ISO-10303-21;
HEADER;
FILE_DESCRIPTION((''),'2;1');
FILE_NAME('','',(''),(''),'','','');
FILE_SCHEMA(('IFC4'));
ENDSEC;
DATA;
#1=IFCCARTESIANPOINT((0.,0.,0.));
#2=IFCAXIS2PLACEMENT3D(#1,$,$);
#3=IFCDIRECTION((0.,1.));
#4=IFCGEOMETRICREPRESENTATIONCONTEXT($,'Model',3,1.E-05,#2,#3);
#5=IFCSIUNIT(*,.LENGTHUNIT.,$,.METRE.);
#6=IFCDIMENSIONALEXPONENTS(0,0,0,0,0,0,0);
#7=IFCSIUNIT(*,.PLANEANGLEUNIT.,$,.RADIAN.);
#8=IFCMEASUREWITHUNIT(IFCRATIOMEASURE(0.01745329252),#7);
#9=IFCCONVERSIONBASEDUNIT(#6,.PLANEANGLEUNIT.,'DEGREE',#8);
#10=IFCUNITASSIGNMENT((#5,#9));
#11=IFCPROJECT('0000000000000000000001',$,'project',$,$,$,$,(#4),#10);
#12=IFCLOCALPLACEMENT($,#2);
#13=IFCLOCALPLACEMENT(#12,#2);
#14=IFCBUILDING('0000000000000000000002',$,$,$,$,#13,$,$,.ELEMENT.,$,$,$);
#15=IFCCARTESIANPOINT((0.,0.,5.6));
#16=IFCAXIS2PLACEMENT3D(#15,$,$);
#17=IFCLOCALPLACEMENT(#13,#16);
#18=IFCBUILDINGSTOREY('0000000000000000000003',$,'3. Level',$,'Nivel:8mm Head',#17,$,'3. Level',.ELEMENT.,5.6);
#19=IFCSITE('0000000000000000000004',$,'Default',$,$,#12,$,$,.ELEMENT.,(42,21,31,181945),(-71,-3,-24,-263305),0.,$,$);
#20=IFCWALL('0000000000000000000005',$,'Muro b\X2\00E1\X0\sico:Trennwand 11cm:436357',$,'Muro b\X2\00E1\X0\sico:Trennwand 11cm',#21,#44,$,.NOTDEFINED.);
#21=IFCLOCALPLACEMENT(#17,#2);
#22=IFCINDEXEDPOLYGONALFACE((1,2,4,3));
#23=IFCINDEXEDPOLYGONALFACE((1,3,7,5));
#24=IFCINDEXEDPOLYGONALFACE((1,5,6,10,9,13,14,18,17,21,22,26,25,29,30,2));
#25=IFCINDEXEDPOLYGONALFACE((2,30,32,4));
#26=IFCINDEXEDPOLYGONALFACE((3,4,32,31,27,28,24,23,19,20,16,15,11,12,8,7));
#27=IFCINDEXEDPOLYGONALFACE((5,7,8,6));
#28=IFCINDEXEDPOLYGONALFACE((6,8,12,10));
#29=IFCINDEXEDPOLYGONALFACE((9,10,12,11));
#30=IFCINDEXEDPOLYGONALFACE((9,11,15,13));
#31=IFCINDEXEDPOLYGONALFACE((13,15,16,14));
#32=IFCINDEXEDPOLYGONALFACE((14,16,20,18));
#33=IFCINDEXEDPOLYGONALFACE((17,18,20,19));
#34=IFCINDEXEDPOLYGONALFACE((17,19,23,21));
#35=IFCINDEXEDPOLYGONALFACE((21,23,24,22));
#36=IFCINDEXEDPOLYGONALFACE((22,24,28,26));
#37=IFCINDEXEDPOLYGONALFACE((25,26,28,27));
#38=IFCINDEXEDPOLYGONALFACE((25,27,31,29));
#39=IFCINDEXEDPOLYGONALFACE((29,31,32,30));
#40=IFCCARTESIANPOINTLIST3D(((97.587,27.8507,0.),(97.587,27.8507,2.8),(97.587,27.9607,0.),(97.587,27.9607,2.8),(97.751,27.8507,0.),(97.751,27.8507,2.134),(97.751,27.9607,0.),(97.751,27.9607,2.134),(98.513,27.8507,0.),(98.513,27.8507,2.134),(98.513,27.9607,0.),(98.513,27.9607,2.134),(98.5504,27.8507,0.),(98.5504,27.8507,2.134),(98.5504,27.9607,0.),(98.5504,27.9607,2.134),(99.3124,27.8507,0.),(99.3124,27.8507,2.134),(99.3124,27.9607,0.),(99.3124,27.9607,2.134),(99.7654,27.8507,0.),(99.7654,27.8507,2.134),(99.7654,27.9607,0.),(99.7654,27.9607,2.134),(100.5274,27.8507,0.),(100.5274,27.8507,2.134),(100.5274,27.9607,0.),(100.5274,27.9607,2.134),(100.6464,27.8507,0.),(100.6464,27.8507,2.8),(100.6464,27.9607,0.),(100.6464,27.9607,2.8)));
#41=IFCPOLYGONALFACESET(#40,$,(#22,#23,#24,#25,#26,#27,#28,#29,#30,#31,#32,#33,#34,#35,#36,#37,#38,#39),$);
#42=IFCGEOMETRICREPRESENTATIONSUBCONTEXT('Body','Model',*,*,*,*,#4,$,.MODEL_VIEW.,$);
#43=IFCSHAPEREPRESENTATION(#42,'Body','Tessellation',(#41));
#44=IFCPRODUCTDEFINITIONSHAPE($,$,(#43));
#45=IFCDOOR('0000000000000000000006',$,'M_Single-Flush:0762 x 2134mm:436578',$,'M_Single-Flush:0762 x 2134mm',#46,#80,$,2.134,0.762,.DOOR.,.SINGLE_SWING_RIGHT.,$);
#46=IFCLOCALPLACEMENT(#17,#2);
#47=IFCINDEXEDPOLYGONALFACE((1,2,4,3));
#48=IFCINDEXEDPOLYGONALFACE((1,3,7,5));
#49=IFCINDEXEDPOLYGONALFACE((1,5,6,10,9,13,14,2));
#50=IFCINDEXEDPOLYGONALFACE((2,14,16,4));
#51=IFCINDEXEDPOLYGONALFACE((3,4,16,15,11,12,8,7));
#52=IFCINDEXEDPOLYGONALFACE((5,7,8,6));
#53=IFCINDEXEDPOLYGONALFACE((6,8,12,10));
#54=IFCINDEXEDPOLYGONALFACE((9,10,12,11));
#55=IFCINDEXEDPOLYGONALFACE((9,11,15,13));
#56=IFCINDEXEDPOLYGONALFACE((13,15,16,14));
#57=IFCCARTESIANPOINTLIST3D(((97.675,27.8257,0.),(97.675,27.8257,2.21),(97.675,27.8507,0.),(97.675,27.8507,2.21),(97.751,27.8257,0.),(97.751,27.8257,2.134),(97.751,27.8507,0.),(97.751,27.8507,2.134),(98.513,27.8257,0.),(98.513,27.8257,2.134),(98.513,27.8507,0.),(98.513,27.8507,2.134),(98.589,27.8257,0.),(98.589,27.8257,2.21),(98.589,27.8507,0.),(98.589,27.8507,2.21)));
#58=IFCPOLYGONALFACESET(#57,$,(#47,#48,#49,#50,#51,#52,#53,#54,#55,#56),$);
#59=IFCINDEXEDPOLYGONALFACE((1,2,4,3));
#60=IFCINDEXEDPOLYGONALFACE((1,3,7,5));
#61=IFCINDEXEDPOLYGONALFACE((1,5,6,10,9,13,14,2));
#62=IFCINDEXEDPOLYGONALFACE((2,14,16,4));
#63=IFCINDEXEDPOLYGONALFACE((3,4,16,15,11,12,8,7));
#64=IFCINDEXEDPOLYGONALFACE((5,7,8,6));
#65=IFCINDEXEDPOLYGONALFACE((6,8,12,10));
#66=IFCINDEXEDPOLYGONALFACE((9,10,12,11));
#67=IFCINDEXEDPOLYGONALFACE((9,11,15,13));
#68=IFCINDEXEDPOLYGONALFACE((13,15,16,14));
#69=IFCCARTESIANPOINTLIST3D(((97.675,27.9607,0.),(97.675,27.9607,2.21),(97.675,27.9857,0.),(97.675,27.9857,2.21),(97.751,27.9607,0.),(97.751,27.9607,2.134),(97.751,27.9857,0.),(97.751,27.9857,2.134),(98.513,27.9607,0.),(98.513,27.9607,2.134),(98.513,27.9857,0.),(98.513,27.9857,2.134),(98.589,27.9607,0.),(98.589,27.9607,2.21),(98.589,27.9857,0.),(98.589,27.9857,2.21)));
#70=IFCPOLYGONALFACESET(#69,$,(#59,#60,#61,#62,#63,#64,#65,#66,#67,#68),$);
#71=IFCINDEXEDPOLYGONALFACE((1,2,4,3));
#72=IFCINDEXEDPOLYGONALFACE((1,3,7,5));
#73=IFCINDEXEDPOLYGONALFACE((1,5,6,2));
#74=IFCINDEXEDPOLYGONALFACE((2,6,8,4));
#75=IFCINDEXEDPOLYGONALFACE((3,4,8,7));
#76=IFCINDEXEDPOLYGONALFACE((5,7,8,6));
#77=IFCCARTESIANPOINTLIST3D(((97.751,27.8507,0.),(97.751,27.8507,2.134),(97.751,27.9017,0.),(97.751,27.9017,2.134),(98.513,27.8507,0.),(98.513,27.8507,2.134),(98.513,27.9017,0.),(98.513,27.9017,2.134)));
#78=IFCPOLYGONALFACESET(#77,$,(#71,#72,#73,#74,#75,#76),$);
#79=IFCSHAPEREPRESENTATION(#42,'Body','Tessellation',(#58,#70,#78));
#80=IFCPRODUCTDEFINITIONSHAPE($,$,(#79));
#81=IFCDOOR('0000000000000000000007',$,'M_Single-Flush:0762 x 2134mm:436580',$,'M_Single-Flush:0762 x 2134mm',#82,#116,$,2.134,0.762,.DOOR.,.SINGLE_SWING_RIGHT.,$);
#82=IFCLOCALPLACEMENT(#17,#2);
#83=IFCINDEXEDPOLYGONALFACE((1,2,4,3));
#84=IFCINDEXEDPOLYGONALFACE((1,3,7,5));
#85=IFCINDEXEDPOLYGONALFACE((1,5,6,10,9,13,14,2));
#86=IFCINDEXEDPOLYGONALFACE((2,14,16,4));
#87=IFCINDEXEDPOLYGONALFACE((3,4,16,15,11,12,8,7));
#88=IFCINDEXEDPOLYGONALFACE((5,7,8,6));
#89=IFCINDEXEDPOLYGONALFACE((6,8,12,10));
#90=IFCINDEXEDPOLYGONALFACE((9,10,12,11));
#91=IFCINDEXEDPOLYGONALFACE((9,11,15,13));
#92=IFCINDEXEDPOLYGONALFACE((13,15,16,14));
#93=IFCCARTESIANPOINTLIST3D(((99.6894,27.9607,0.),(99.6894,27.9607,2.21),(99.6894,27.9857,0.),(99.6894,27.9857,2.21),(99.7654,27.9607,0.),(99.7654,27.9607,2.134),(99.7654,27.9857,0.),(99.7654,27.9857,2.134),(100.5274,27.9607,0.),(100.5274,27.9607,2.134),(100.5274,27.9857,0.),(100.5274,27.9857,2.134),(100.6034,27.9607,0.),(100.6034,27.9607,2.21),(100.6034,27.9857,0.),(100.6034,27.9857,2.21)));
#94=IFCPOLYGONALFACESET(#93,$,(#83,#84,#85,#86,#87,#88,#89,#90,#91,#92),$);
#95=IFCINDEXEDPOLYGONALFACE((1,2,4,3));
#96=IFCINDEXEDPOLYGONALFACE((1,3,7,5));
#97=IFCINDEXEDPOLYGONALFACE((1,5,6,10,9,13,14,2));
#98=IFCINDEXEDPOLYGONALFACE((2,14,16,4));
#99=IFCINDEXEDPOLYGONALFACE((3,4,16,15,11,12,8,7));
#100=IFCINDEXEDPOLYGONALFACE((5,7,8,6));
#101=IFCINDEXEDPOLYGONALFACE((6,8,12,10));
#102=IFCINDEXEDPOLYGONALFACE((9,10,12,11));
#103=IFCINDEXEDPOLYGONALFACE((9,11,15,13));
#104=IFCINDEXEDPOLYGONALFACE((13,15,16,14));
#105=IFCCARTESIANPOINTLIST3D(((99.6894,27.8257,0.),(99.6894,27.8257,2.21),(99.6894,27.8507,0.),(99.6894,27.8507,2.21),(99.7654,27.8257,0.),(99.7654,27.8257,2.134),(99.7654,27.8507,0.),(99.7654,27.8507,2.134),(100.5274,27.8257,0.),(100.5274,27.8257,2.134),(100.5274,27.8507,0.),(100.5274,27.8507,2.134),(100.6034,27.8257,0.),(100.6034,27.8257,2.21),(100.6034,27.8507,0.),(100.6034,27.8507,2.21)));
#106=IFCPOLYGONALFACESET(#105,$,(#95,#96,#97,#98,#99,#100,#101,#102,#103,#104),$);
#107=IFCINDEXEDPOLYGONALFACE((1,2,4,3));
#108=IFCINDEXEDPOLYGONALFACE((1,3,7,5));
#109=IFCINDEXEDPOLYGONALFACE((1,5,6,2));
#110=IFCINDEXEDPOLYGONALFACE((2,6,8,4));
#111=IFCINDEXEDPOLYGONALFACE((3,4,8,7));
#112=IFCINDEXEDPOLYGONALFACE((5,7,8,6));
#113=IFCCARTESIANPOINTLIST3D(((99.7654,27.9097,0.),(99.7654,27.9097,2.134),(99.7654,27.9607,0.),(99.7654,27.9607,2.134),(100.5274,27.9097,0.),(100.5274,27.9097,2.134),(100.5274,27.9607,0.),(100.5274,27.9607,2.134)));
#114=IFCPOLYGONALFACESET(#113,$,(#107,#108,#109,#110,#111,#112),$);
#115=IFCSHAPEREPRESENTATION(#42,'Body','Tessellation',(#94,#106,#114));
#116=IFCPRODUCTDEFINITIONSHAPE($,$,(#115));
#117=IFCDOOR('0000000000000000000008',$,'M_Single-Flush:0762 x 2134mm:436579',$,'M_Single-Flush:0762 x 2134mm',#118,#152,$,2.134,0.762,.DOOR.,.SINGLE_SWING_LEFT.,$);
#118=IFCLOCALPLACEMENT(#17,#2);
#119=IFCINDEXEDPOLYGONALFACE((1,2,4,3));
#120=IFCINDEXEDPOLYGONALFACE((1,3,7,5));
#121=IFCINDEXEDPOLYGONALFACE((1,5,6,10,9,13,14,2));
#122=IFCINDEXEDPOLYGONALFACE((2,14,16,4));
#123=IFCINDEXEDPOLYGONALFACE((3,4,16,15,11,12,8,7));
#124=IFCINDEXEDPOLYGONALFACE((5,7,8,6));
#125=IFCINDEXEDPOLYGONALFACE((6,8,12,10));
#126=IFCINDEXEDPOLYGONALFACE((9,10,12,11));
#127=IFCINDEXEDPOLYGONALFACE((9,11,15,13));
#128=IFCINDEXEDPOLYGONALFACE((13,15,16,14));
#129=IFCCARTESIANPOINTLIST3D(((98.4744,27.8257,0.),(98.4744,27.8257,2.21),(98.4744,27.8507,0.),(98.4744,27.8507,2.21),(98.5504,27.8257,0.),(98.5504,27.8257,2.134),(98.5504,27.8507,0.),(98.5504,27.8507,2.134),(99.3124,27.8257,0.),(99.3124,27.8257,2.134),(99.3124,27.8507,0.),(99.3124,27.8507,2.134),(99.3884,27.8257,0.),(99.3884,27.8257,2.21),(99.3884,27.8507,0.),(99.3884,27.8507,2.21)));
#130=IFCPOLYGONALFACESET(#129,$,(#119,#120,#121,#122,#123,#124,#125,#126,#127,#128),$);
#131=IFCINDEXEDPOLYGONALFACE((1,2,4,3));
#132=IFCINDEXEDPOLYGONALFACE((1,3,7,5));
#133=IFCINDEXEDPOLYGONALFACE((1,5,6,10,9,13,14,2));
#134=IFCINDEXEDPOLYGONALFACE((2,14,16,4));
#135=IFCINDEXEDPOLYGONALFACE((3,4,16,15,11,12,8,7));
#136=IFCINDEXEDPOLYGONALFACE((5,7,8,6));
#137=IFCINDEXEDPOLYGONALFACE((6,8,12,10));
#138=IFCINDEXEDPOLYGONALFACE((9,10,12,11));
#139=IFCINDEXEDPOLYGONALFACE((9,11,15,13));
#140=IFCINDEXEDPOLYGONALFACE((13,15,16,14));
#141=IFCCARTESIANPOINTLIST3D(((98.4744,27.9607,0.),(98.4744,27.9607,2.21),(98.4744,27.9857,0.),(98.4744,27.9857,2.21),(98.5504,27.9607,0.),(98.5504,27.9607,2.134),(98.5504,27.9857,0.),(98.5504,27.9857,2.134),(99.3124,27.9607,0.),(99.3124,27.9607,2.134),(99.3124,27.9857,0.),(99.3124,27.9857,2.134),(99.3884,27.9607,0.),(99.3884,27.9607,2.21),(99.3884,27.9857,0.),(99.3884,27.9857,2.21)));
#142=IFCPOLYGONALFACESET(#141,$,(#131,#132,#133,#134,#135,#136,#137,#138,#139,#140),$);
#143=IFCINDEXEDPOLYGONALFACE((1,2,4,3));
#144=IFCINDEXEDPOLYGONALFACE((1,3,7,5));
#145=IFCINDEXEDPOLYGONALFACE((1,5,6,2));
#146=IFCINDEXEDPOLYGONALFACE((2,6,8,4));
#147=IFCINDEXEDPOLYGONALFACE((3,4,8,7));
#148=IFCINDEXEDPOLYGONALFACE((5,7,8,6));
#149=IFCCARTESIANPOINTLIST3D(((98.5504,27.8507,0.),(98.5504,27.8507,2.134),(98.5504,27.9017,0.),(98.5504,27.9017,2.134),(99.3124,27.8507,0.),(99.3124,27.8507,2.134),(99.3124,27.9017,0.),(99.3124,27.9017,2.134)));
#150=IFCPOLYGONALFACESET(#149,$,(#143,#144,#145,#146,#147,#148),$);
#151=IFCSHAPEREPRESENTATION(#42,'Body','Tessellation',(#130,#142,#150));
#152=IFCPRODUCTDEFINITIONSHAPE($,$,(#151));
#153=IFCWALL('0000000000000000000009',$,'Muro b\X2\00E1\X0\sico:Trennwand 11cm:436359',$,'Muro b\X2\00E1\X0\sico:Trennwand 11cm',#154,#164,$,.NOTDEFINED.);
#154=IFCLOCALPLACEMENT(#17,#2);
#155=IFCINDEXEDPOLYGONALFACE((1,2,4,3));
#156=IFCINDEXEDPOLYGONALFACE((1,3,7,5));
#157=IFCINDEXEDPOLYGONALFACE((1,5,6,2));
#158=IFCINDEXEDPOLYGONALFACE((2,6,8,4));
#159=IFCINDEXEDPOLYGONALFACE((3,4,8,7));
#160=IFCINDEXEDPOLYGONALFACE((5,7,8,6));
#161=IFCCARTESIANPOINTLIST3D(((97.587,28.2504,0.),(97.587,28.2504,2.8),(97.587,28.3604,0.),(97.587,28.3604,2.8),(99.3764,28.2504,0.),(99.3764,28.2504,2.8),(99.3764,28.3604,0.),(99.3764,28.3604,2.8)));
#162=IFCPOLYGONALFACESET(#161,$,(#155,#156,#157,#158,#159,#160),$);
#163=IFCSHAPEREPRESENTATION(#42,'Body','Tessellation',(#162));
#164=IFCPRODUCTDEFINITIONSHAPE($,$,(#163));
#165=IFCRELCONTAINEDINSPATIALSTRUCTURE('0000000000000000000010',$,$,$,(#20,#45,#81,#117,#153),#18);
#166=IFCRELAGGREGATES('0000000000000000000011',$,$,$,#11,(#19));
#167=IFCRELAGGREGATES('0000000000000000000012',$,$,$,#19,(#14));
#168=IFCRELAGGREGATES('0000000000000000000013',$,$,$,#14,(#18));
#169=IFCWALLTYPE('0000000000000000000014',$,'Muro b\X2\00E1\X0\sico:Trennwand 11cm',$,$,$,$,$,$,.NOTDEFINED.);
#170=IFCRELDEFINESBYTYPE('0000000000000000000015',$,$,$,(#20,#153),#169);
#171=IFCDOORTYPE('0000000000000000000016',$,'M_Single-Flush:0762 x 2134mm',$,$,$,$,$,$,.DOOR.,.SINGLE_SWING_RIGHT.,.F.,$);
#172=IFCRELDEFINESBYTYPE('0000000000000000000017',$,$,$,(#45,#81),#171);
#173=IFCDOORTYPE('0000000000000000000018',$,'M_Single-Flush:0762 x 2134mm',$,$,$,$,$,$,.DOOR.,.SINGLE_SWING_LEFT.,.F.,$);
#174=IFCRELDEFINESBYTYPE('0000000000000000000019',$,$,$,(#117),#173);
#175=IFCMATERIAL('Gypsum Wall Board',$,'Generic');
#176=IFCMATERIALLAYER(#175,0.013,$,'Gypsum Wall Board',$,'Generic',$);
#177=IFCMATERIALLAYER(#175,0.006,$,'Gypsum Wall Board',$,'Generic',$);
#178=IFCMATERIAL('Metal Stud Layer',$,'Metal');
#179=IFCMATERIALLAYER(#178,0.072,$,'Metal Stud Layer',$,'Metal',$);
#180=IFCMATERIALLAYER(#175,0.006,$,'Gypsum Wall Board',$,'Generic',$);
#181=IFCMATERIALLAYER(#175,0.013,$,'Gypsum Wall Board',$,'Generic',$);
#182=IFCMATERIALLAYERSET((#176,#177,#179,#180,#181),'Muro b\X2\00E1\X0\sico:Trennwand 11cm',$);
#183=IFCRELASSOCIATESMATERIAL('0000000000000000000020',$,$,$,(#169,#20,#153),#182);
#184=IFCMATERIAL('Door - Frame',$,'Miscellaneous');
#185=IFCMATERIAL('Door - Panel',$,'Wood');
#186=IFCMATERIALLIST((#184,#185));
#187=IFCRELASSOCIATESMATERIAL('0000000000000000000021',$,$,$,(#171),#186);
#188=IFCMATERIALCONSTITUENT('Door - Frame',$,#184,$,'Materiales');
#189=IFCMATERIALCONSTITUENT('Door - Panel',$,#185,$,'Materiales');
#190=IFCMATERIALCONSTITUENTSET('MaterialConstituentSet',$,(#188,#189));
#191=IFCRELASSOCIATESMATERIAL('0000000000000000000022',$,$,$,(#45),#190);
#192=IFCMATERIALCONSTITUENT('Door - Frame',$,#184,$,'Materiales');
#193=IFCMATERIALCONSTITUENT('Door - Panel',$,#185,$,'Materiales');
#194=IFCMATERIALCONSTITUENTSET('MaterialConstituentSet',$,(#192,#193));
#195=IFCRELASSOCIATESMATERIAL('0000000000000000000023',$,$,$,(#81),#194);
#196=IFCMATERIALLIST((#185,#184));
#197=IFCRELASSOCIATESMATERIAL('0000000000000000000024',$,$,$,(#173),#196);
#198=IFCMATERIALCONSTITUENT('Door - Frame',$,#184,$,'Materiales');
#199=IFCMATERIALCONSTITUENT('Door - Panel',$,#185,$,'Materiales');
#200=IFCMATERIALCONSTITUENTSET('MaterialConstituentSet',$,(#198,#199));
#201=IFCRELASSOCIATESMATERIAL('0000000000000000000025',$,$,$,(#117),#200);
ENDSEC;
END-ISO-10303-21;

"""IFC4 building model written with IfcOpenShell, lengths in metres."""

from ifc_helpers import new_model, entity, si_unit, converted_unit, direction, frame, frame_2d, origin, origin_2d_with_axis, place, context, subcontext, project, spatial, polyline, rectangle, outline, extrude, source, transform, mapped, material, material_list, layer, layer_set, layer_usage, constituent, constituent_set, type_object, type_shapes, element, fill, save


model = new_model("IFC4")

# Units and contexts
model_context = context("Model", 3, precision=1e-05, world=origin(), true_north=direction((0.0, 1.0)))
body_context = subcontext(model_context, "Body", "Model", "MODEL_VIEW")
ifc_project = project(units=[si_unit("LENGTHUNIT", "METRE"), converted_unit("PLANEANGLEUNIT", "DEGREE", entity("IfcRatioMeasure", 0.01745329252), si_unit("PLANEANGLEUNIT", "RADIAN"), dimensions=[0, 0, 0, 0, 0, 0, 0])], contexts=[model_context])

# Site, building, storey
site_placement = place(None, origin())
site = spatial("IfcSite", under=ifc_project, at=site_placement, Name="Default", CompositionType="ELEMENT", RefLatitude=(42, 21, 31, 181945), RefLongitude=(-71, -3, -24, -263305), RefElevation=0.0)
building_placement = place(site_placement, origin())
building = spatial("IfcBuilding", under=site, at=building_placement, CompositionType="ELEMENT")
storey_placement = place(building_placement, frame((0.0, 0.0, 5.6)))
storey = spatial("IfcBuildingStorey", under=building, at=storey_placement, Name="3. Level", ObjectType="Nivel:8mm Head", LongName="3. Level", CompositionType="ELEMENT", Elevation=5.6)

# Shared definitions
ifc_material_1 = material(Name="Gypsum Wall Board", Category="Generic")
ifc_layer_1 = layer(ifc_material_1, 0.013, Name="Gypsum Wall Board", Category="Generic")
ifc_layer_2 = layer(ifc_material_1, 0.006, Name="Gypsum Wall Board", Category="Generic")
ifc_material_2 = material(Name="Metal Stud Layer", Category="Metal")
ifc_layer_3 = layer(ifc_material_2, 0.072, Name="Metal Stud Layer", Category="Metal")
ifc_layer_4 = layer(ifc_material_1, 0.006, Name="Gypsum Wall Board", Category="Generic")
ifc_layer_5 = layer(ifc_material_1, 0.013, Name="Gypsum Wall Board", Category="Generic")
ifc_layer_set_1 = layer_set([ifc_layer_1, ifc_layer_2, ifc_layer_3, ifc_layer_4, ifc_layer_5], Name="Muro básico:Trennwand 11cm")
wall_type_1 = type_object("IfcWallType", Name="Muro básico:Trennwand 11cm", PredefinedType="NOTDEFINED", material=ifc_layer_set_1)

# Wall, openings, doors
ifc_material_3 = material(Name="Door - Frame", Category="Miscellaneous")
ifc_material_4 = material(Name="Door - Panel", Category="Wood")
ifc_material_list_1 = material_list([ifc_material_3, ifc_material_4])
door_type_1 = type_object("IfcDoorType", Name="M_Single-Flush:0762 x 2134mm", OperationType="SINGLE_SWING_RIGHT", ParameterTakesPrecedence=False, PredefinedType="DOOR", material=ifc_material_list_1)
shared_shape_1 = source(origin(), body_context, "Body", "SweptSolid", [
    extrude(outline(polyline([(-0.457, -1.124), (0.457, -1.124), (0.457, 1.086), (0.381, 1.086), (0.381, -1.048), (-0.381, -1.048), (-0.381, 1.086), (-0.457, 1.086), (-0.457, -1.124)])), frame((0.381, 0.11, 1.086), z_axis=(0.0, 1.0, 0.0), x_axis=(1.0, 0.0, 0.0)), (0.0, 0.0, 1.0), 0.025),
    extrude(outline(polyline([(-1.124, -0.457), (1.086, -0.457), (1.086, -0.381), (-1.048, -0.381), (-1.048, 0.381), (1.086, 0.381), (1.086, 0.457), (-1.124, 0.457), (-1.124, -0.457)])), frame((0.381, -0.025, 1.086), z_axis=(0.0, 1.0, 0.0), x_axis=(0.0, 0.0, -1.0)), (0.0, 0.0, 1.0), 0.025),
    extrude(rectangle(XDim=0.051, YDim=0.762, at=origin_2d_with_axis()), frame((0.381, 0.0845, 0.0), z_axis=(0.0, 0.0, 1.0), x_axis=(0.0, 1.0, 0.0)), (0.0, 0.0, 1.0), 2.134),
])
type_shapes(door_type_1, [shared_shape_1])
ifc_layer_usage_1 = layer_usage(ifc_layer_set_1, "AXIS2", "NEGATIVE", 0.055)
wall_1_placement = place(storey_placement, frame((97.587, 27.9057, 0.0)))
wall_1 = element("IfcWall", 1, at=wall_1_placement, inside=storey, type_object=wall_type_1, material=ifc_layer_usage_1, Name="Muro básico:Trennwand 11cm:436357", ObjectType="Muro básico:Trennwand 11cm", PredefinedType="NOTDEFINED", context=body_context, shape_type="SweptSolid", body=[
    extrude(rectangle(XDim=3.0594, YDim=0.11, at=frame_2d((1.5297, 0.0), x_axis=(-1.0, 0.0))), origin(), (0.0, 0.0, 1.0), 2.8),
])
opening_1_placement = place(wall_1_placement, frame((0.926, 0.055, 0.0)))
opening_1 = element("IfcOpeningElement", 2, at=opening_1_placement, cuts=wall_1, ObjectType="Opening", PredefinedType="OPENING", context=body_context, shape_type="SweptSolid", body=[
    extrude(rectangle(XDim=0.762, YDim=2.134, at=frame_2d((1.067, 0.381), x_axis=(0.0, 1.0))), frame((0.0, 0.0, 0.0), z_axis=(0.0, -1.0, 0.0), x_axis=(0.0, 0.0, 1.0)), (0.0, 0.0, 1.0), 0.11),
])
opening_2_placement = place(wall_1_placement, frame((1.7254, 0.055, 0.0)))
opening_2 = element("IfcOpeningElement", 3, at=opening_2_placement, cuts=wall_1, ObjectType="Opening", PredefinedType="OPENING", context=body_context, shape_type="SweptSolid", body=[
    extrude(rectangle(XDim=0.762, YDim=2.134, at=frame_2d((1.067, 0.381), x_axis=(0.0, -1.0))), frame((0.0, 0.0, 0.0), z_axis=(0.0, -1.0, 0.0), x_axis=(0.0, 0.0, 1.0)), (0.0, 0.0, 1.0), 0.11),
])
opening_3_placement = place(wall_1_placement, frame((2.1784, -0.055, 0.0)))
opening_3 = element("IfcOpeningElement", 4, at=opening_3_placement, cuts=wall_1, ObjectType="Opening", PredefinedType="OPENING", context=body_context, shape_type="SweptSolid", body=[
    extrude(rectangle(XDim=0.762, YDim=2.134, at=frame_2d((1.067, 0.381), x_axis=(0.0, 1.0))), frame((0.0, 0.0, 0.0), z_axis=(0.0, 1.0, 0.0), x_axis=(0.0, 0.0, 1.0)), (0.0, 0.0, 1.0), 0.11),
])
ifc_constituent_1 = constituent(ifc_material_3, Name="Door - Frame", Category="Materiales")
ifc_constituent_2 = constituent(ifc_material_4, Name="Door - Panel", Category="Materiales")
ifc_constituent_set_1 = constituent_set(constituents=[ifc_constituent_1, ifc_constituent_2], Name="MaterialConstituentSet")
door_1_placement = place(opening_1_placement, frame((0.0, 0.0, 0.0), z_axis=(0.0, 0.0, 1.0), x_axis=(-1.0, 0.0, 0.0)))
door_1 = element("IfcDoor", 5, at=door_1_placement, inside=storey, type_object=door_type_1, material=ifc_constituent_set_1, Name="M_Single-Flush:0762 x 2134mm:436578", ObjectType="M_Single-Flush:0762 x 2134mm", OperationType="SINGLE_SWING_RIGHT", OverallHeight=2.134, OverallWidth=0.762, PredefinedType="DOOR", context=body_context, shape_type="MappedRepresentation", body=[
    mapped(shared_shape_1, transform((0.0, 0.0, 0.0), scale=1.0)),
])
fill(opening_1, door_1)
ifc_constituent_3 = constituent(ifc_material_3, Name="Door - Frame", Category="Materiales")
ifc_constituent_4 = constituent(ifc_material_4, Name="Door - Panel", Category="Materiales")
ifc_constituent_set_2 = constituent_set(constituents=[ifc_constituent_3, ifc_constituent_4], Name="MaterialConstituentSet")
door_2_placement = place(opening_3_placement, origin())
door_2 = element("IfcDoor", 6, at=door_2_placement, inside=storey, type_object=door_type_1, material=ifc_constituent_set_2, Name="M_Single-Flush:0762 x 2134mm:436580", ObjectType="M_Single-Flush:0762 x 2134mm", OperationType="SINGLE_SWING_RIGHT", OverallHeight=2.134, OverallWidth=0.762, PredefinedType="DOOR", context=body_context, shape_type="MappedRepresentation", body=[
    mapped(shared_shape_1, transform((0.0, 0.0, 0.0), scale=1.0)),
])
fill(opening_3, door_2)
ifc_constituent_5 = constituent(ifc_material_3, Name="Door - Frame", Category="Materiales")
ifc_constituent_6 = constituent(ifc_material_4, Name="Door - Panel", Category="Materiales")
ifc_constituent_set_3 = constituent_set(constituents=[ifc_constituent_5, ifc_constituent_6], Name="MaterialConstituentSet")
ifc_material_list_2 = material_list([ifc_material_4, ifc_material_3])
door_type_2 = type_object("IfcDoorType", Name="M_Single-Flush:0762 x 2134mm", OperationType="SINGLE_SWING_LEFT", ParameterTakesPrecedence=False, PredefinedType="DOOR", material=ifc_material_list_2)
shared_shape_2 = source(origin(), body_context, "Body", "SweptSolid", [
    extrude(outline(polyline([(-0.457, -1.124), (0.457, -1.124), (0.457, 1.086), (0.381, 1.086), (0.381, -1.048), (-0.381, -1.048), (-0.381, 1.086), (-0.457, 1.086), (-0.457, -1.124)])), frame((0.381, 0.135, 1.086), z_axis=(0.0, -1.0, 0.0), x_axis=(-1.0, 0.0, 0.0)), (0.0, 0.0, 1.0), 0.025),
    extrude(outline(polyline([(-1.124, -0.457), (1.086, -0.457), (1.086, -0.381), (-1.048, -0.381), (-1.048, 0.381), (1.086, 0.381), (1.086, 0.457), (-1.124, 0.457), (-1.124, -0.457)])), frame((0.381, 0.0, 1.086), z_axis=(0.0, -1.0, 0.0), x_axis=(0.0, 0.0, -1.0)), (0.0, 0.0, 1.0), 0.025),
    extrude(rectangle(XDim=0.762, YDim=0.051, at=origin_2d_with_axis()), frame((0.381, 0.0845, 0.0)), (0.0, 0.0, 1.0), 2.134),
])
type_shapes(door_type_2, [shared_shape_2])
door_3_placement = place(opening_2_placement, frame((0.0, 0.0, 0.0), z_axis=(0.0, 0.0, 1.0), x_axis=(-1.0, 0.0, 0.0)))
door_3 = element("IfcDoor", 7, at=door_3_placement, inside=storey, type_object=door_type_2, material=ifc_constituent_set_3, Name="M_Single-Flush:0762 x 2134mm:436579", ObjectType="M_Single-Flush:0762 x 2134mm", OperationType="SINGLE_SWING_LEFT", OverallHeight=2.134, OverallWidth=0.762, PredefinedType="DOOR", context=body_context, shape_type="MappedRepresentation", body=[
    mapped(shared_shape_2, transform((0.0, 0.0, 0.0), scale=1.0)),
])
fill(opening_2, door_3)

# Wall
ifc_layer_usage_2 = layer_usage(ifc_layer_set_1, "AXIS2", "NEGATIVE", 0.055)
wall_2_placement = place(storey_placement, frame((99.3764, 28.3054, 0.0), z_axis=(0.0, 0.0, 1.0), x_axis=(-1.0, 0.0, 0.0)))
element("IfcWall", 8, at=wall_2_placement, inside=storey, type_object=wall_type_1, material=ifc_layer_usage_2, Name="Muro básico:Trennwand 11cm:436359", ObjectType="Muro básico:Trennwand 11cm", PredefinedType="NOTDEFINED", context=body_context, shape_type="SweptSolid", body=[
    extrude(rectangle(XDim=1.7894, YDim=0.11, at=frame_2d((0.8947, 0.0), x_axis=(-1.0, 0.0))), origin(), (0.0, 0.0, 1.0), 2.8),
])

save(model, "model.ifc")
